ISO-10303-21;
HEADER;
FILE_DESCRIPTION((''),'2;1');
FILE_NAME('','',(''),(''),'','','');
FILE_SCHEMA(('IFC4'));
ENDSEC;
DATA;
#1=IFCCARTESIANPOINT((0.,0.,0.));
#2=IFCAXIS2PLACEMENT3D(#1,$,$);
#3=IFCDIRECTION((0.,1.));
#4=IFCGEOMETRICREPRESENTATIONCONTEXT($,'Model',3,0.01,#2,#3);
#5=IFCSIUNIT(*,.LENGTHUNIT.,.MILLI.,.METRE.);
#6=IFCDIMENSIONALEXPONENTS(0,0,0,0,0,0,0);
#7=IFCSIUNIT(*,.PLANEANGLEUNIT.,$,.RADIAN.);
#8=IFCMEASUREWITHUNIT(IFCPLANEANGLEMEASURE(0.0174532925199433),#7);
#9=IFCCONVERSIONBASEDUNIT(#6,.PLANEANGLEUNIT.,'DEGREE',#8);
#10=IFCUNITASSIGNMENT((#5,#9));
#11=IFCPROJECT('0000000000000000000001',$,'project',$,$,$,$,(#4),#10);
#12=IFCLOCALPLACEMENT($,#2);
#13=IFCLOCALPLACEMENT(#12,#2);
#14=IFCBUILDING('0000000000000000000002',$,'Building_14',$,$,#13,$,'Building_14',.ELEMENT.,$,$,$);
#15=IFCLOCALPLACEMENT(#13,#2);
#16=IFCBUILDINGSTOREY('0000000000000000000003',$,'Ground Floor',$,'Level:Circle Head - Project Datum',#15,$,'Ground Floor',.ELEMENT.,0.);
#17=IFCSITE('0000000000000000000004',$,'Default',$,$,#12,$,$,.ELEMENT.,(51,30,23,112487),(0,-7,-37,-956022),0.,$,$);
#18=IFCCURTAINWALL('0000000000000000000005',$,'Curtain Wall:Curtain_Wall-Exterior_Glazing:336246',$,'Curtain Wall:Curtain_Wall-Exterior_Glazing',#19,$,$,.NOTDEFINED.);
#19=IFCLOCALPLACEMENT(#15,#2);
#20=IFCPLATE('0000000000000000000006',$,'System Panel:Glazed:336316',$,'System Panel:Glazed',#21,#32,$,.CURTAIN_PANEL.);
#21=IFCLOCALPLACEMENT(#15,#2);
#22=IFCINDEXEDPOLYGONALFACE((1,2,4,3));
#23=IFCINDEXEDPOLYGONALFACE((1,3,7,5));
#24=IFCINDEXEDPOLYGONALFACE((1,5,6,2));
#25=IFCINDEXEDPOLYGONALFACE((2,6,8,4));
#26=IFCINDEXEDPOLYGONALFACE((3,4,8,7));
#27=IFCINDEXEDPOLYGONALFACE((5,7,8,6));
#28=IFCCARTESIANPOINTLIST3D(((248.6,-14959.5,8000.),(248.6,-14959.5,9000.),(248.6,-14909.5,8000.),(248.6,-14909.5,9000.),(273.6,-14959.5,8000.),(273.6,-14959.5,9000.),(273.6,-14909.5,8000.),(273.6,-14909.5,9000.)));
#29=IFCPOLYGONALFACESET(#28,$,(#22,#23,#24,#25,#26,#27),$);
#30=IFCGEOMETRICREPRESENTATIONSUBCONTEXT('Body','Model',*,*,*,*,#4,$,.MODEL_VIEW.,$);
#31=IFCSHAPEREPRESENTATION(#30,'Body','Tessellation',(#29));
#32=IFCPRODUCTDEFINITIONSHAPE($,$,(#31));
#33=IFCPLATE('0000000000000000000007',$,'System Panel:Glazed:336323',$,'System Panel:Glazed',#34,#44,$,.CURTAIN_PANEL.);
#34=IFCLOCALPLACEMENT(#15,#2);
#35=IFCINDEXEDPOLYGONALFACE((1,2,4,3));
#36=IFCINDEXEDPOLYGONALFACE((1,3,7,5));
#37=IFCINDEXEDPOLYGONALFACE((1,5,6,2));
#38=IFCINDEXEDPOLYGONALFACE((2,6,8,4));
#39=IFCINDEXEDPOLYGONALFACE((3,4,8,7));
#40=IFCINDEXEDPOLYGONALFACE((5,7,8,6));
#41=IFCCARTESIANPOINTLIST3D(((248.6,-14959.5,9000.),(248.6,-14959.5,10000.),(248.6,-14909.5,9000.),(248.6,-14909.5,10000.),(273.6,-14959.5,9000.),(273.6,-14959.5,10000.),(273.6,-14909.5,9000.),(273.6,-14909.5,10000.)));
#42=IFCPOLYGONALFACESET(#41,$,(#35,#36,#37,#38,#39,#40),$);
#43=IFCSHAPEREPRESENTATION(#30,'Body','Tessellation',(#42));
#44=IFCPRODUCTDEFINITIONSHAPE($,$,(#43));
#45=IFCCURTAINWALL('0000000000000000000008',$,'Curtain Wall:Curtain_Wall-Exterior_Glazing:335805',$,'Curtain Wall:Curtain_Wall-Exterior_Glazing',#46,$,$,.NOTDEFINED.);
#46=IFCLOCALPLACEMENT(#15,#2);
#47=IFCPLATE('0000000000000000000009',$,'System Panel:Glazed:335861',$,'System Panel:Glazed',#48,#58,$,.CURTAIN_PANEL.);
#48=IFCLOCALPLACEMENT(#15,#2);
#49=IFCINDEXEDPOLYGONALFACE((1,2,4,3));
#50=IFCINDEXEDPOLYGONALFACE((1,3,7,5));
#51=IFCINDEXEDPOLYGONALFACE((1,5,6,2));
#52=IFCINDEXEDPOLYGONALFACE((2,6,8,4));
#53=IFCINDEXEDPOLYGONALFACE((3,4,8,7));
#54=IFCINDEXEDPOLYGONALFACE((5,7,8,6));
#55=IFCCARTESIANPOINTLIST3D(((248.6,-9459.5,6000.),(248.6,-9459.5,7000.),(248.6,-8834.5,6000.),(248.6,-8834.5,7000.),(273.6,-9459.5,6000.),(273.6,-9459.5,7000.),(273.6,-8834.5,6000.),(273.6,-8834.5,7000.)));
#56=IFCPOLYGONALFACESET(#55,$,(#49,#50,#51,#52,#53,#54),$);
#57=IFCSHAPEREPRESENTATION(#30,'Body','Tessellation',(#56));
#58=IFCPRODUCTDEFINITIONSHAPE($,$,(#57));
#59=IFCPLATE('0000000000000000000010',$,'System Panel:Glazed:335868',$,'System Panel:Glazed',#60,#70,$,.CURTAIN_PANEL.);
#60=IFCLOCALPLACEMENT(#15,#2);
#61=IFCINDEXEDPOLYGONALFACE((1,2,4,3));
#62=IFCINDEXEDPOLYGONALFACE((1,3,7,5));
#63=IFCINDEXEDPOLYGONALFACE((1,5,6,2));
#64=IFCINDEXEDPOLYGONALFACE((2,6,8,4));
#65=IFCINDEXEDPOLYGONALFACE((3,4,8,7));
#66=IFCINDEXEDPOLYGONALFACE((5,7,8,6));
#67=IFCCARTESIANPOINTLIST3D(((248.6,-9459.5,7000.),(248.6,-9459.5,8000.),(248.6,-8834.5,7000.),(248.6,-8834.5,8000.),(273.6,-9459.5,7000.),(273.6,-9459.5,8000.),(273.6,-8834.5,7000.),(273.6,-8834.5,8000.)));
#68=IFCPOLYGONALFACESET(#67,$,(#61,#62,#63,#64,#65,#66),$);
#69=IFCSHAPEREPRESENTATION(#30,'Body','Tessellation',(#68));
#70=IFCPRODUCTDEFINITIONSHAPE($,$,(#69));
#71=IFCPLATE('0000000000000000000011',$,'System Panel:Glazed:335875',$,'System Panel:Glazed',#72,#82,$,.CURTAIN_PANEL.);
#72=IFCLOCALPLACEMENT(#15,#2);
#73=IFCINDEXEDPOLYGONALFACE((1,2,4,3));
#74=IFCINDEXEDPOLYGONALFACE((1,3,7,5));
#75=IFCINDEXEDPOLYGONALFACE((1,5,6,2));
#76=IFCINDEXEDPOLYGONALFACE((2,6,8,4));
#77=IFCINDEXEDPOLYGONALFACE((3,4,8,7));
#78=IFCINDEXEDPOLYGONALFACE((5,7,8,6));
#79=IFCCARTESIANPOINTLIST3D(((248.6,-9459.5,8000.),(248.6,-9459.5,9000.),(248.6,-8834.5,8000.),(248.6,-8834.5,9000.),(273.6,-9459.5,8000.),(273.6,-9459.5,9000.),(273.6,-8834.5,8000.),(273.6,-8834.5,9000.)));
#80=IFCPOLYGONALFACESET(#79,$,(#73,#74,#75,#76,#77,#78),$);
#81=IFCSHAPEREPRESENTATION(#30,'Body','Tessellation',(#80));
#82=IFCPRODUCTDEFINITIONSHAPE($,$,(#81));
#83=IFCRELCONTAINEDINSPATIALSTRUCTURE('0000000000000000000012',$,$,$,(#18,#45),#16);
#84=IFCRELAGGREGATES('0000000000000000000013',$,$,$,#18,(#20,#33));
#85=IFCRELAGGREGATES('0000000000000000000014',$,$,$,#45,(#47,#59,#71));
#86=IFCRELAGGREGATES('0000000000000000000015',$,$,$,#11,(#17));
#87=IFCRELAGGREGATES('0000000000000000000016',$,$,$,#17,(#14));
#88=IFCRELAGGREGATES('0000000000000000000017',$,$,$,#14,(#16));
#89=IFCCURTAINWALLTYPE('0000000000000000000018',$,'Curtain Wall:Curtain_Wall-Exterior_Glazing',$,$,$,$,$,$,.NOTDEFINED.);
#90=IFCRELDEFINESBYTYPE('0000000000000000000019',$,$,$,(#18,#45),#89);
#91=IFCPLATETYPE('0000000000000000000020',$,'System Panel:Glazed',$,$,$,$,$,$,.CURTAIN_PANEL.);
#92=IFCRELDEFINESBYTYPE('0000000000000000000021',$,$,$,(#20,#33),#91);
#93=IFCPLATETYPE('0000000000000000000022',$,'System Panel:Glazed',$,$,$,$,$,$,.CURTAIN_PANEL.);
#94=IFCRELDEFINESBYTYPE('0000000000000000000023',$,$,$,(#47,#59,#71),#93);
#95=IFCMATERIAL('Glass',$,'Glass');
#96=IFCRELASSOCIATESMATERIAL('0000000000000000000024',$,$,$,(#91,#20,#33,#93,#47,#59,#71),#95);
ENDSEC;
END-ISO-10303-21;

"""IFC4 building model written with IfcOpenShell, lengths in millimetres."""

from ifc_helpers import new_model, entity, si_unit, converted_unit, direction, frame, origin, place, context, subcontext, project, spatial, indexed_curve, outline, extrude, source, transform, mapped, material, type_object, type_shapes, element, aggregate, save


model = new_model("IFC4")

# Units and contexts
model_context = context("Model", 3, precision=0.01, world=origin(), true_north=direction((0.0, 1.0)))
body_context = subcontext(model_context, "Body", "Model", "MODEL_VIEW")
ifc_project = project(units=[si_unit("LENGTHUNIT", "METRE", prefix="MILLI"), converted_unit("PLANEANGLEUNIT", "DEGREE", entity("IfcPlaneAngleMeasure", 0.0174532925199433), si_unit("PLANEANGLEUNIT", "RADIAN"), dimensions=[0, 0, 0, 0, 0, 0, 0])], contexts=[model_context])

# Site, building, storey
site_placement = place(None, origin())
site = spatial("IfcSite", under=ifc_project, at=site_placement, Name="Default", CompositionType="ELEMENT", RefLatitude=(51, 30, 23, 112487), RefLongitude=(0, -7, -37, -956022), RefElevation=0.0)
building_placement = place(site_placement, origin())
building = spatial("IfcBuilding", under=site, at=building_placement, Name="Building_14", LongName="Building_14", CompositionType="ELEMENT")
storey_placement = place(building_placement, origin())
storey = spatial("IfcBuildingStorey", under=building, at=storey_placement, Name="Ground Floor", ObjectType="Level:Circle Head - Project Datum", LongName="Ground Floor", CompositionType="ELEMENT", Elevation=0.0)

# Curtain walls, plates
curtain_wall_type = type_object("IfcCurtainWallType", Name="Curtain Wall:Curtain_Wall-Exterior_Glazing", PredefinedType="NOTDEFINED")
curtain_wall_1_placement = place(storey_placement, origin())
curtain_wall_1 = element("IfcCurtainWall", 1, at=curtain_wall_1_placement, inside=storey, type_object=curtain_wall_type, Name="Curtain Wall:Curtain_Wall-Exterior_Glazing:336246", ObjectType="Curtain Wall:Curtain_Wall-Exterior_Glazing", PredefinedType="NOTDEFINED")
ifc_material = material(Name="Glass", Category="Glass")
plate_type_1 = type_object("IfcPlateType", Name="System Panel:Glazed", PredefinedType="CURTAIN_PANEL", material=ifc_material)
shared_shape_1 = source(origin(), body_context, "Body", "SweptSolid", [
    extrude(outline(indexed_curve([(-12.5, -25.0), (12.5, -25.0), (12.5, 25.0), (-12.5, 25.0), (-12.5, -25.0)], self_intersect=False)), frame((0.0, -37.0, 0.0), z_axis=(0.0, 0.0, 1.0), x_axis=(0.0, 1.0, 0.0)), (0.0, 0.0, 1.0), 1000.0),
])
type_shapes(plate_type_1, [shared_shape_1])
plate_1_placement = place(curtain_wall_1_placement, frame((298.1, -14934.5, 8000.0), z_axis=(0.0, 0.0, 1.0), x_axis=(0.0, -1.0, 0.0)))
plate_1 = element("IfcPlate", 2, at=plate_1_placement, type_object=plate_type_1, material=ifc_material, Name="System Panel:Glazed:336316", ObjectType="System Panel:Glazed", PredefinedType="CURTAIN_PANEL", context=body_context, shape_type="MappedRepresentation", body=[
    mapped(shared_shape_1, transform((0.0, 0.0, 0.0), scale=1.0)),
])
plate_2_placement = place(curtain_wall_1_placement, frame((298.1, -14934.5, 9000.0), z_axis=(0.0, 0.0, 1.0), x_axis=(0.0, -1.0, 0.0)))
plate_2 = element("IfcPlate", 3, at=plate_2_placement, type_object=plate_type_1, material=ifc_material, Name="System Panel:Glazed:336323", ObjectType="System Panel:Glazed", PredefinedType="CURTAIN_PANEL", context=body_context, shape_type="MappedRepresentation", body=[
    mapped(shared_shape_1, transform((0.0, 0.0, 0.0), scale=1.0)),
])
aggregate(curtain_wall_1, [plate_1, plate_2])
curtain_wall_2_placement = place(storey_placement, origin())
curtain_wall_2 = element("IfcCurtainWall", 4, at=curtain_wall_2_placement, inside=storey, type_object=curtain_wall_type, Name="Curtain Wall:Curtain_Wall-Exterior_Glazing:335805", ObjectType="Curtain Wall:Curtain_Wall-Exterior_Glazing", PredefinedType="NOTDEFINED")
plate_type_2 = type_object("IfcPlateType", Name="System Panel:Glazed", PredefinedType="CURTAIN_PANEL", material=ifc_material)
shared_shape_2 = source(origin(), body_context, "Body", "SweptSolid", [
    extrude(outline(indexed_curve([(-12.5, -312.5), (12.5, -312.5), (12.5, 312.5), (-12.5, 312.5), (-12.5, -312.5)], self_intersect=False)), frame((0.0, -37.0, 0.0), z_axis=(0.0, 0.0, 1.0), x_axis=(0.0, 1.0, 0.0)), (0.0, 0.0, 1.0), 1000.0),
])
type_shapes(plate_type_2, [shared_shape_2])
plate_3_placement = place(curtain_wall_2_placement, frame((298.1, -9147.0, 6000.0), z_axis=(0.0, 0.0, 1.0), x_axis=(0.0, -1.0, 0.0)))
plate_3 = element("IfcPlate", 5, at=plate_3_placement, type_object=plate_type_2, material=ifc_material, Name="System Panel:Glazed:335861", ObjectType="System Panel:Glazed", PredefinedType="CURTAIN_PANEL", context=body_context, shape_type="MappedRepresentation", body=[
    mapped(shared_shape_2, transform((0.0, 0.0, 0.0), scale=1.0)),
])
plate_4_placement = place(curtain_wall_2_placement, frame((298.1, -9147.0, 7000.0), z_axis=(0.0, 0.0, 1.0), x_axis=(0.0, -1.0, 0.0)))
plate_4 = element("IfcPlate", 6, at=plate_4_placement, type_object=plate_type_2, material=ifc_material, Name="System Panel:Glazed:335868", ObjectType="System Panel:Glazed", PredefinedType="CURTAIN_PANEL", context=body_context, shape_type="MappedRepresentation", body=[
    mapped(shared_shape_2, transform((0.0, 0.0, 0.0), scale=1.0)),
])
plate_5_placement = place(curtain_wall_2_placement, frame((298.1, -9147.0, 8000.0), z_axis=(0.0, 0.0, 1.0), x_axis=(0.0, -1.0, 0.0)))
plate_5 = element("IfcPlate", 7, at=plate_5_placement, type_object=plate_type_2, material=ifc_material, Name="System Panel:Glazed:335875", ObjectType="System Panel:Glazed", PredefinedType="CURTAIN_PANEL", context=body_context, shape_type="MappedRepresentation", body=[
    mapped(shared_shape_2, transform((0.0, 0.0, 0.0), scale=1.0)),
])
aggregate(curtain_wall_2, [plate_3, plate_4, plate_5])

save(model, "model.ifc")
